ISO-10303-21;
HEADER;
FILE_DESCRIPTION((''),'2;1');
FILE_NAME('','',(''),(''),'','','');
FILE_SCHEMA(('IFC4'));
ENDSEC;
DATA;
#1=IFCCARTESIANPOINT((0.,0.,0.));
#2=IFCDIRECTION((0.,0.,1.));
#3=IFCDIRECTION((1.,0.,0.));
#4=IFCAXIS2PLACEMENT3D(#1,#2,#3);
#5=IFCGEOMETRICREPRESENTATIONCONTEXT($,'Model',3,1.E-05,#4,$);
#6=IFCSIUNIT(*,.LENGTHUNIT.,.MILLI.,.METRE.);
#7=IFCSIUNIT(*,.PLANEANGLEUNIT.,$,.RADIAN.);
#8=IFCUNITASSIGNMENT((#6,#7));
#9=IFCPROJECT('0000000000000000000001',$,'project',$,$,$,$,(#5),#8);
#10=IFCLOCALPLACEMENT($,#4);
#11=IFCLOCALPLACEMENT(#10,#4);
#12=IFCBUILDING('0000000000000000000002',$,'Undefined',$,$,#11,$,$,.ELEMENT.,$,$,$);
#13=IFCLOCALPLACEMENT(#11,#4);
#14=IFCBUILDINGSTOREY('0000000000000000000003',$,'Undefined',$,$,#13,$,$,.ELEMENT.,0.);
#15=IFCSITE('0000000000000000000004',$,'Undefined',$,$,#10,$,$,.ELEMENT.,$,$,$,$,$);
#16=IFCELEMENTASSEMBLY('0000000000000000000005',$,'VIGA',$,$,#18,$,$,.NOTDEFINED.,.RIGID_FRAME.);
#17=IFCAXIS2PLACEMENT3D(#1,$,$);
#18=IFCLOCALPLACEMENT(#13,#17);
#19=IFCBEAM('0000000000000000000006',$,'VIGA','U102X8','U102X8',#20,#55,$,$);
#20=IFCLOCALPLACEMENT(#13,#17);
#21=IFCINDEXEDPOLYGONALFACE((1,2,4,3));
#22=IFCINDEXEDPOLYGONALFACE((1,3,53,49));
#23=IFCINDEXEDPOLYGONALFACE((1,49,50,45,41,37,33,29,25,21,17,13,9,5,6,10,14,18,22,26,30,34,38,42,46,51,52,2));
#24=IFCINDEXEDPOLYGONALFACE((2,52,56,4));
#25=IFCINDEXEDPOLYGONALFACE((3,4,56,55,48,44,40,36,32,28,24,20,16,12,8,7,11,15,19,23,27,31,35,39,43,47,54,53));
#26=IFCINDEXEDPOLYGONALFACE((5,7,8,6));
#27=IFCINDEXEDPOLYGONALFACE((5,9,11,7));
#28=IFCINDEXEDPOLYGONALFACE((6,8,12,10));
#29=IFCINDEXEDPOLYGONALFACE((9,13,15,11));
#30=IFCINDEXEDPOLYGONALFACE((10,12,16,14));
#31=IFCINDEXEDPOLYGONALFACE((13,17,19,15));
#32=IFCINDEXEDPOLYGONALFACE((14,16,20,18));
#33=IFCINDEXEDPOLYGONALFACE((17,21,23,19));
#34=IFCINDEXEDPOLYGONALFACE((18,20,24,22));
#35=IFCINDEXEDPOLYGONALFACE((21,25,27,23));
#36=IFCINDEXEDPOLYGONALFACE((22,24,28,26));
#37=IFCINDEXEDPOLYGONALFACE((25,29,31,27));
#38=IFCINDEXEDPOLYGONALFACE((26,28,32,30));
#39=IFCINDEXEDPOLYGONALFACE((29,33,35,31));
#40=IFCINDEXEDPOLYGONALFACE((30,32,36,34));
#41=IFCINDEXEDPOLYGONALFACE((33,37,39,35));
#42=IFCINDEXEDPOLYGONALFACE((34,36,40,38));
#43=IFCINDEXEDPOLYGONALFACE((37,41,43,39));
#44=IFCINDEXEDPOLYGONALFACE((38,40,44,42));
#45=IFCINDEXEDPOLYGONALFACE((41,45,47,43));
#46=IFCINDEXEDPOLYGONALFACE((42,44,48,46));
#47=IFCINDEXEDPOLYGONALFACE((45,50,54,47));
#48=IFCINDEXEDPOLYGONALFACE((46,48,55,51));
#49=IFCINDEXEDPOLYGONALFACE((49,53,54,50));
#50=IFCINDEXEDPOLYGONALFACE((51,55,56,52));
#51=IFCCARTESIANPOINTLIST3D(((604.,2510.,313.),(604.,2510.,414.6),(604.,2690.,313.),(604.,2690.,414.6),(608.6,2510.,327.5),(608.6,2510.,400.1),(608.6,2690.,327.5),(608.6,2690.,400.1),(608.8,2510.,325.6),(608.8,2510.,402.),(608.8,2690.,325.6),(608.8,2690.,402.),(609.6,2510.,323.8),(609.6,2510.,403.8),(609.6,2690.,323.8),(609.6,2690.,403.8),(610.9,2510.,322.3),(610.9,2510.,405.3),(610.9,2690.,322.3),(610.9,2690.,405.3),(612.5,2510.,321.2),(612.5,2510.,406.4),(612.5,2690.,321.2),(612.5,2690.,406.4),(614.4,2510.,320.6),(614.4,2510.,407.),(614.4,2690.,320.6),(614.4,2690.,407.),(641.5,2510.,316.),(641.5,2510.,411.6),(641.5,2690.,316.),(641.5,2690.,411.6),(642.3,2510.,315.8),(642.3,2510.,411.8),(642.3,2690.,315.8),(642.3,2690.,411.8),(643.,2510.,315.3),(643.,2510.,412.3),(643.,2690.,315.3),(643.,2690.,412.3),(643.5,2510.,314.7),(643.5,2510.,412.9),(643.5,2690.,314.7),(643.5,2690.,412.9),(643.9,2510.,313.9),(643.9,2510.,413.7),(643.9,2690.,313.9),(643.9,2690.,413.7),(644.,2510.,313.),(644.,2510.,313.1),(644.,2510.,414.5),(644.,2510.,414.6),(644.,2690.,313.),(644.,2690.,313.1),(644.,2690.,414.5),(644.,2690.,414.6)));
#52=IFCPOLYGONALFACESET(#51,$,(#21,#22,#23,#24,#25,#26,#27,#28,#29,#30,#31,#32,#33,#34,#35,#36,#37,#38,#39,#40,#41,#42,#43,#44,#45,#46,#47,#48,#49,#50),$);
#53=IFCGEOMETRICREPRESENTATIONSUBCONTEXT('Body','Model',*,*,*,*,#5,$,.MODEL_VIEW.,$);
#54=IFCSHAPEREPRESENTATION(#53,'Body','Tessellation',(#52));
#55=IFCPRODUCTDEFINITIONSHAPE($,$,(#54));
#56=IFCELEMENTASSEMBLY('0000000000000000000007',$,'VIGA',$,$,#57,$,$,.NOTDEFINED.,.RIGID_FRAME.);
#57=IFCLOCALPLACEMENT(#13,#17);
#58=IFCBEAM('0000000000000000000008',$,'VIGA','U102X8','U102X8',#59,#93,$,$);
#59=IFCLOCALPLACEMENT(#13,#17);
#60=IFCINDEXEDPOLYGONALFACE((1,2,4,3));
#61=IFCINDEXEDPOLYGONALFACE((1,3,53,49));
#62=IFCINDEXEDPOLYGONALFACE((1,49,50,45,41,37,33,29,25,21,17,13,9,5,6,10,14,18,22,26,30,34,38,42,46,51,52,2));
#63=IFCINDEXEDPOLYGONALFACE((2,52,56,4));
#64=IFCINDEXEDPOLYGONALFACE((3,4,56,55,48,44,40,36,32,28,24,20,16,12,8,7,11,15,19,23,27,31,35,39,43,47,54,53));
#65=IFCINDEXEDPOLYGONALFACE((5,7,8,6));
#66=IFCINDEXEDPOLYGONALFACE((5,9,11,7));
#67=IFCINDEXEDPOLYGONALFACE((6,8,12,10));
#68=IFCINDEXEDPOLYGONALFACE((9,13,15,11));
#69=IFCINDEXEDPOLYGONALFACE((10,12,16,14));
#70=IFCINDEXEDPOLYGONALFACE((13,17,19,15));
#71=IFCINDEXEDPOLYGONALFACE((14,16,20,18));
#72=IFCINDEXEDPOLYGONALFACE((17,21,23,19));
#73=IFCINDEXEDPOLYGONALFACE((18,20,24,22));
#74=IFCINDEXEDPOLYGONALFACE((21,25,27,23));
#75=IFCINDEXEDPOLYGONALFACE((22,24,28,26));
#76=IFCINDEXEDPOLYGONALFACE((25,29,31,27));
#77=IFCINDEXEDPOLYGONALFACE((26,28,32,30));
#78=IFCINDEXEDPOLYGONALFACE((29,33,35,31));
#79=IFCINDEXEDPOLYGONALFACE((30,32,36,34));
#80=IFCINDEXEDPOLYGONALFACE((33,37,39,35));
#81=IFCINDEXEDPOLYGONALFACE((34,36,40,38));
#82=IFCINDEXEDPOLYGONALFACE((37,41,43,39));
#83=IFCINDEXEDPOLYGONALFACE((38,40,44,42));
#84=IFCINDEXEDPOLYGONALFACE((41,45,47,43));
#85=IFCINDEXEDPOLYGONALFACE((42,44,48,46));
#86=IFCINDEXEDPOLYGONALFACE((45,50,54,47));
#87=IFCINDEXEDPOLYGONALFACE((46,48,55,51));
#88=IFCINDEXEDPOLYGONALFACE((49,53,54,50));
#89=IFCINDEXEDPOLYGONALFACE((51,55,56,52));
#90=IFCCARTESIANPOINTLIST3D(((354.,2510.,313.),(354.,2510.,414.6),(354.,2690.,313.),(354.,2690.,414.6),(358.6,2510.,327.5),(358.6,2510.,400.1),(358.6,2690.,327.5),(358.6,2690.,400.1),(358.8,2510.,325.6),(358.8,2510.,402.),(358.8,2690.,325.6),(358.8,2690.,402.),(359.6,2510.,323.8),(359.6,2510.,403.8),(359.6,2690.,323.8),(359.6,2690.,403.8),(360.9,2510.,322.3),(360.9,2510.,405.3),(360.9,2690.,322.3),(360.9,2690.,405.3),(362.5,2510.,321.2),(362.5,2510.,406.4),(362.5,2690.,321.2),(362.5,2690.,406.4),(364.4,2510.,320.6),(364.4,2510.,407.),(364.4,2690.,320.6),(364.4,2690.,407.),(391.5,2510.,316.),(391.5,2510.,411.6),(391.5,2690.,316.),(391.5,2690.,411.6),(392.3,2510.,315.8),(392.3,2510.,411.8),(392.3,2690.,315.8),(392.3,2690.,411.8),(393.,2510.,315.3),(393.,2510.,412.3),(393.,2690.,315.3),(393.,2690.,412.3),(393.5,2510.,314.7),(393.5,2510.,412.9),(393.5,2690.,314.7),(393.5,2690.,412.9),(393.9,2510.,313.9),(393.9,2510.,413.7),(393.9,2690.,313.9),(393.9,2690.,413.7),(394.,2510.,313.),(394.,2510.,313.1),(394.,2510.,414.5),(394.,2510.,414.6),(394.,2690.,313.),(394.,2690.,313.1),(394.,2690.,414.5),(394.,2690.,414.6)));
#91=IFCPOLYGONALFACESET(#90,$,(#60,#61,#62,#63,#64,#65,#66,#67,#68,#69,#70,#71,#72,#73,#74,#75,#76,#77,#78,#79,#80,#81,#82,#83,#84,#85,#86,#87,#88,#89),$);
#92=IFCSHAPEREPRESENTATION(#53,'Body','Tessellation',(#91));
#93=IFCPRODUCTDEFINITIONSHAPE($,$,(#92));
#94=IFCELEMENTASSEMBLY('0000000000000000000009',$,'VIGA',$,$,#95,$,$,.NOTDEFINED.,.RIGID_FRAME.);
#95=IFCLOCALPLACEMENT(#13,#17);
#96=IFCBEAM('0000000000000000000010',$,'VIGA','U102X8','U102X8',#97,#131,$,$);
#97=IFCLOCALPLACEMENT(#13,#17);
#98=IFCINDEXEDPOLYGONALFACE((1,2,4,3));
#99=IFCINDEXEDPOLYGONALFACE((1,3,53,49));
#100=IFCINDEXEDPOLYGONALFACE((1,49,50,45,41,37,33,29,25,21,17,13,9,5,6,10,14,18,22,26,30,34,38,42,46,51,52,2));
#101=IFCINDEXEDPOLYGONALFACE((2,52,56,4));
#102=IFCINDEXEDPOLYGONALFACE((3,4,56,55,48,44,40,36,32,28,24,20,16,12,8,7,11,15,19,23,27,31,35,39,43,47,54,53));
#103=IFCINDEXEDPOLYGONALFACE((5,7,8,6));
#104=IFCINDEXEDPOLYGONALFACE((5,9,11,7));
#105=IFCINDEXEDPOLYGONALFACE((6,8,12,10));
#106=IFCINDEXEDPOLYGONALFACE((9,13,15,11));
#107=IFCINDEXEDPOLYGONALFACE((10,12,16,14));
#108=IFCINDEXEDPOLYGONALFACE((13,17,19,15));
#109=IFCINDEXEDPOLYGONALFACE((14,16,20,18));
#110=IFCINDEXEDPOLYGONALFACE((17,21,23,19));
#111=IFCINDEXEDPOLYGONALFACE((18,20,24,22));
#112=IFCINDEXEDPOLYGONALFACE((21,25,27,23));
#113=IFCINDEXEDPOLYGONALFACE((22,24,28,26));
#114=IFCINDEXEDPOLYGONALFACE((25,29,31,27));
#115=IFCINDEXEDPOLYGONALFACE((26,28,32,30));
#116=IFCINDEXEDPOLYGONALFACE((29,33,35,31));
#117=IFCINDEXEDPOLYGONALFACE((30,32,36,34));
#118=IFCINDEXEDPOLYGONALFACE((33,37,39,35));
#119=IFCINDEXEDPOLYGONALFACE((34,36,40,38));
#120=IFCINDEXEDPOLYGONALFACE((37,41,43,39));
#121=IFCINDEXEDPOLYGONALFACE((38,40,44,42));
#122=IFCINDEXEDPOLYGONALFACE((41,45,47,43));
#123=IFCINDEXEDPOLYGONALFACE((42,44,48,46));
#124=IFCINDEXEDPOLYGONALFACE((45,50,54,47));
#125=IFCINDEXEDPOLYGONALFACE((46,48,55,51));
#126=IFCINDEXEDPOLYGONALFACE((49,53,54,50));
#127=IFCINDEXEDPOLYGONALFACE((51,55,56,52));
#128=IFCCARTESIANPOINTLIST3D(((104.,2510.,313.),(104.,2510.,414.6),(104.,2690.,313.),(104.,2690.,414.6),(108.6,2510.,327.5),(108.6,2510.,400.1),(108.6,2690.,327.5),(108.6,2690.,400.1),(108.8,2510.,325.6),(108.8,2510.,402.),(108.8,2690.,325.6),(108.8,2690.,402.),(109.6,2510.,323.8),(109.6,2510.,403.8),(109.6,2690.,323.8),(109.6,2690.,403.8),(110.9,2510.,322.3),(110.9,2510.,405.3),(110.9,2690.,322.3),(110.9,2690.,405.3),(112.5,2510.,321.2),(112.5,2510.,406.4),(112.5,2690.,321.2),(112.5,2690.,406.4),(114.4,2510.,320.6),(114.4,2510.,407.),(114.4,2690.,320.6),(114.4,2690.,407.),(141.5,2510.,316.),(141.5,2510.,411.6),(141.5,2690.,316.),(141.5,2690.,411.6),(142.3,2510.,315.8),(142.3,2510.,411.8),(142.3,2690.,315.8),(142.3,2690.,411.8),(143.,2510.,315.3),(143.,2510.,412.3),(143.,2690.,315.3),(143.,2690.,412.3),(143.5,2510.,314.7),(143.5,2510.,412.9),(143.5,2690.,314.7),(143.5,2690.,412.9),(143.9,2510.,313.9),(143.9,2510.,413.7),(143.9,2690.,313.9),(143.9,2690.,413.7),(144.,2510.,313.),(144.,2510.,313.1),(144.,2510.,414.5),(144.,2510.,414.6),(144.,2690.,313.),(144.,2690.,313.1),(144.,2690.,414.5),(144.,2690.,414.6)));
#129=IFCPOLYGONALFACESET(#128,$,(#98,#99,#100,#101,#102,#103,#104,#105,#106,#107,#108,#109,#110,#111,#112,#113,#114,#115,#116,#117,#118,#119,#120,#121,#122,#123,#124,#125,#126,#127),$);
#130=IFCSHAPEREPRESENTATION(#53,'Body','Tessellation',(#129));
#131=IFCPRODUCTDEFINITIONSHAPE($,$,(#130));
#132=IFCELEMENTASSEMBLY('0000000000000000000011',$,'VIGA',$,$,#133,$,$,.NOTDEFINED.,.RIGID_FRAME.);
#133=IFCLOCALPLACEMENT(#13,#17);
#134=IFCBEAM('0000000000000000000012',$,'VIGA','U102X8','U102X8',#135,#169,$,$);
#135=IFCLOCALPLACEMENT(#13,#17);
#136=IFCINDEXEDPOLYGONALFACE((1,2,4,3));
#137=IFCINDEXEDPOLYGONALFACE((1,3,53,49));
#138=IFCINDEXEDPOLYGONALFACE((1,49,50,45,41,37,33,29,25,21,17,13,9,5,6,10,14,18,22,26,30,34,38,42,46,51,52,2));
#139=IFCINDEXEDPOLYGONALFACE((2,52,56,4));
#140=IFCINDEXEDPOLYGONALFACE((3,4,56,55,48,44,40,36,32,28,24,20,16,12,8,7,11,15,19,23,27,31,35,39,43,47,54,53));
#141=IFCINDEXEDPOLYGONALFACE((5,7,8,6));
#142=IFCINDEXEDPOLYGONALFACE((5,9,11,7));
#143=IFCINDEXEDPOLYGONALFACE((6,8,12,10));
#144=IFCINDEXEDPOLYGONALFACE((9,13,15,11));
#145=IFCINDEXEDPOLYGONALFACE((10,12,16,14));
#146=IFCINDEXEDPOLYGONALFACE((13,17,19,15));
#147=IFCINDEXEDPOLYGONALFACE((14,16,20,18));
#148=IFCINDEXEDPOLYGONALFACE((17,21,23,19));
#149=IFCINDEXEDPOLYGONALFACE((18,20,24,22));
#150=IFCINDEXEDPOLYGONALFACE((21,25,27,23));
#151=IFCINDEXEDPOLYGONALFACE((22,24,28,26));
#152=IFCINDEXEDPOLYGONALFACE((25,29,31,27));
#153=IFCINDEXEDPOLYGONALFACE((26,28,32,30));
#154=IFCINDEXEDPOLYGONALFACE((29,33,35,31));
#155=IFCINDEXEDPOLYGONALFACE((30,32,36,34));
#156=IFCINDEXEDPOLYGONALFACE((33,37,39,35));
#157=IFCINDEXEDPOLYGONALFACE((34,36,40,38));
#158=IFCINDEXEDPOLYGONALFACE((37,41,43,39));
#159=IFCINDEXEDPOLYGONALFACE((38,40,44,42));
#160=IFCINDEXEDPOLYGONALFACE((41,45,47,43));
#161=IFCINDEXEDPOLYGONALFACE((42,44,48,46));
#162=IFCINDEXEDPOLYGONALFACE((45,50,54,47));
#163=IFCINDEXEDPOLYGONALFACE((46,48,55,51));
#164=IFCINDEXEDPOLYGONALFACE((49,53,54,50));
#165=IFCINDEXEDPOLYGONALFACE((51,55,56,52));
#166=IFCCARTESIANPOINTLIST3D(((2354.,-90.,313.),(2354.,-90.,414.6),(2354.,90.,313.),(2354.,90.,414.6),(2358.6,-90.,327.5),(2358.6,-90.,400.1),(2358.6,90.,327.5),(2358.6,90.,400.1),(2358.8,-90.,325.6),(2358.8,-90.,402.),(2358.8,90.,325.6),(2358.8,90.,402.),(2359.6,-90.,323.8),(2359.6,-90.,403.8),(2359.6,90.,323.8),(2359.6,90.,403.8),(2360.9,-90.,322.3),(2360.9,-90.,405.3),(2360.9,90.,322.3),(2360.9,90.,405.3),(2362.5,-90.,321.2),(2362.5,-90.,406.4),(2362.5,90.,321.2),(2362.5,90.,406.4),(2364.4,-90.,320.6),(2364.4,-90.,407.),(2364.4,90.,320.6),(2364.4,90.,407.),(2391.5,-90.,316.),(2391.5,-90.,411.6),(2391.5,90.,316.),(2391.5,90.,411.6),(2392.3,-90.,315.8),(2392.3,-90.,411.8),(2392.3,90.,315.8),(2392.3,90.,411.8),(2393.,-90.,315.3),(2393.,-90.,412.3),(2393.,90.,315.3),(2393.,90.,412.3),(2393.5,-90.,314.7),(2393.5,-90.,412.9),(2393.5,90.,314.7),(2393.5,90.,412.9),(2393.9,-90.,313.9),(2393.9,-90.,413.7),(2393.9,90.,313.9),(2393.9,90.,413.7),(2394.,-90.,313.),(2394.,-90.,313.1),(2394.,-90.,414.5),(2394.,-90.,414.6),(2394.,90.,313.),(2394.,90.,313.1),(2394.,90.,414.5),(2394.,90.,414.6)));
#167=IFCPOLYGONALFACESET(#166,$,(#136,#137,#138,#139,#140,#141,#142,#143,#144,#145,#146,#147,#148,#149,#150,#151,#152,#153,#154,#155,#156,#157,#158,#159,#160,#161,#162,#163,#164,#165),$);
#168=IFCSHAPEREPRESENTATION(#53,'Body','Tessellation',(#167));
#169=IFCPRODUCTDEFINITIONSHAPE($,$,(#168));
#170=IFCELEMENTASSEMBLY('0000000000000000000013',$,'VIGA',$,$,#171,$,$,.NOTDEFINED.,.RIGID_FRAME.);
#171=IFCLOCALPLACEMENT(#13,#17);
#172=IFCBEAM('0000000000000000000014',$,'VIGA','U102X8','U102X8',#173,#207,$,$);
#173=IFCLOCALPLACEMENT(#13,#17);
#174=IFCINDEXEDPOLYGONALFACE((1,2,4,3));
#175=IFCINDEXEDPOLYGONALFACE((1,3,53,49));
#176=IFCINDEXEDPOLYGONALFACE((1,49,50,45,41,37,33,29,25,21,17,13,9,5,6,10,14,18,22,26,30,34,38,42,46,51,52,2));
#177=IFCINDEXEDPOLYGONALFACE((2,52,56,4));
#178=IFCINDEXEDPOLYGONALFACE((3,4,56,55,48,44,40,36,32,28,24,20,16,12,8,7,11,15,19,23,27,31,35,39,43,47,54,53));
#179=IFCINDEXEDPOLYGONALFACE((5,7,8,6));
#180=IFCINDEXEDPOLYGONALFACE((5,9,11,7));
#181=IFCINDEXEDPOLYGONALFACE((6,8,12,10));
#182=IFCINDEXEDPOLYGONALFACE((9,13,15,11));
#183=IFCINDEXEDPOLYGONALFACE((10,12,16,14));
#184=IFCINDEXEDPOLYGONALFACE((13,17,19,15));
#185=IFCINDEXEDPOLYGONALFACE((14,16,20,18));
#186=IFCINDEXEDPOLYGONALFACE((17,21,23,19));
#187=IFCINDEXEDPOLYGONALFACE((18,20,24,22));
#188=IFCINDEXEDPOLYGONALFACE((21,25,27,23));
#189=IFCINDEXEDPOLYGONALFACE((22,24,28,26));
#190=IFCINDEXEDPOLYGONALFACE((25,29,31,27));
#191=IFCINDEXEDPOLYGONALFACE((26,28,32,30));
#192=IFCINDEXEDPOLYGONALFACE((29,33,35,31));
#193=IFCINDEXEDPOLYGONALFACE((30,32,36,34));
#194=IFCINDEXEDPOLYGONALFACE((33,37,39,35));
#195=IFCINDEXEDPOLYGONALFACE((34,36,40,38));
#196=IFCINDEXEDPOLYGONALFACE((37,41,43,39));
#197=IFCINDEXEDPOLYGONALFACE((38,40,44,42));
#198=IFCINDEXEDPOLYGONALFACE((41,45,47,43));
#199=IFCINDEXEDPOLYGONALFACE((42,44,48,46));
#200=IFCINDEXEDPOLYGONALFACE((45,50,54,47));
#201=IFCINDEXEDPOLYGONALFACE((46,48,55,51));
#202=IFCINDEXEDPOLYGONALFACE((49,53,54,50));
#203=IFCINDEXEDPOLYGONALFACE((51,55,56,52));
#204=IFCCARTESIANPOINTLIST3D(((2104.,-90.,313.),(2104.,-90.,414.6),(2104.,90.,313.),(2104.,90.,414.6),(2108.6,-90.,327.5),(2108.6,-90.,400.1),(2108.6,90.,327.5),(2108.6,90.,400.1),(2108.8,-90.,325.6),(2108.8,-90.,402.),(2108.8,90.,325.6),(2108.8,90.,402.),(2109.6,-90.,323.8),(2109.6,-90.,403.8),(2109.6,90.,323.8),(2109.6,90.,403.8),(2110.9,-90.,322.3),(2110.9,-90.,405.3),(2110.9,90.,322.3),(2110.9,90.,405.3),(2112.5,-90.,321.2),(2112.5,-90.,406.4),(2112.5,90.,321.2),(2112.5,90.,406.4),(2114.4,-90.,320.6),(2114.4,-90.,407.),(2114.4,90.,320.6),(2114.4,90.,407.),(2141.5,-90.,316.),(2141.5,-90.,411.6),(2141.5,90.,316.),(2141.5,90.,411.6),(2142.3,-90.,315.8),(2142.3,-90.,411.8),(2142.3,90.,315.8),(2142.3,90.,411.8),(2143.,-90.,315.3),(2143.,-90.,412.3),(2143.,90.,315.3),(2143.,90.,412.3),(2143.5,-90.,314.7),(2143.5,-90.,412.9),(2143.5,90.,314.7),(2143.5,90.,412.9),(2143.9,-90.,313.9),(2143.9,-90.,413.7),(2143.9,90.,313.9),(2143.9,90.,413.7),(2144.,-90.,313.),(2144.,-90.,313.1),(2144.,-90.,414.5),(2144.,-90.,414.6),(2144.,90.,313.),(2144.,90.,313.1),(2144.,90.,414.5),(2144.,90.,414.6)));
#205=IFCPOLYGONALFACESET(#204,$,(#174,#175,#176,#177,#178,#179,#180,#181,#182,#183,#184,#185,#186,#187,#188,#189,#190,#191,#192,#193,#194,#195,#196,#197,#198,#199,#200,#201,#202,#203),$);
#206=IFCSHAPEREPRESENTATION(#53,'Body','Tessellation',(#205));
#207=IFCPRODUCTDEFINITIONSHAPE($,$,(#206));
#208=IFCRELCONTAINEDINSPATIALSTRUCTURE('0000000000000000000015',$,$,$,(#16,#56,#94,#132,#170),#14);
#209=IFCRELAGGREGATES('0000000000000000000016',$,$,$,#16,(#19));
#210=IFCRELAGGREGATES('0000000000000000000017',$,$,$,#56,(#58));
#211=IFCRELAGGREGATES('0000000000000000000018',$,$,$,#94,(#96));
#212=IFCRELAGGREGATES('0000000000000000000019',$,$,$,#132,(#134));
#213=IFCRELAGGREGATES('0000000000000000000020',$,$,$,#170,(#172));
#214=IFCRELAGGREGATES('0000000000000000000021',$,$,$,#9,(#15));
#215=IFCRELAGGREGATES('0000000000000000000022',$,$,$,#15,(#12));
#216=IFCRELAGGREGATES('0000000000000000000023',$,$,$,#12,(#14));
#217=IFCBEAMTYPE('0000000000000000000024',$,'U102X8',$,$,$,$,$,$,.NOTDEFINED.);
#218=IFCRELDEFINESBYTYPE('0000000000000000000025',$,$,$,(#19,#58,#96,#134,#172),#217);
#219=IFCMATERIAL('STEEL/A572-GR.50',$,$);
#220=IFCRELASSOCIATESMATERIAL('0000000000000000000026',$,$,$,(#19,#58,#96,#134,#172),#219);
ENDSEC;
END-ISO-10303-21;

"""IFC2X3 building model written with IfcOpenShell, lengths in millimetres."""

from ifc_helpers import new_model, si_unit, frame, origin_with_axes, origin_2d_with_axis, place, context, subcontext, project, spatial, u_section, extrude, material, type_object, element, aggregate, save


model = new_model("IFC2X3")

# Units and contexts
model_context = context("Model", 3, precision=1e-05, world=origin_with_axes())
body_context = subcontext(model_context, "Body", "Model", "MODEL_VIEW")
ifc_project = project(units=[si_unit("LENGTHUNIT", "METRE", prefix="MILLI"), si_unit("PLANEANGLEUNIT", "RADIAN")], contexts=[model_context])

# Site, building, storey
site_placement = place(None, origin_with_axes())
site = spatial("IfcSite", under=ifc_project, at=site_placement, Name="Undefined", CompositionType="ELEMENT")
building_placement = place(site_placement, origin_with_axes())
building = spatial("IfcBuilding", under=site, at=building_placement, Name="Undefined", CompositionType="ELEMENT")
storey_placement = place(building_placement, origin_with_axes())
storey = spatial("IfcBuildingStorey", under=building, at=storey_placement, Name="Undefined", CompositionType="ELEMENT", Elevation=0.0)

# Element assemblies, beams
ifc_material_1 = material(Name="STEEL/A572-GR.50")
beam_type_1 = type_object("IfcBeamType", Name="U102X8", PredefinedType="NOTDEFINED")
assembly_1_placement = place(storey_placement, origin_with_axes())
assembly_1 = element("IfcElementAssembly", 1, at=assembly_1_placement, inside=storey, Name="VIGA", AssemblyPlace="NOTDEFINED", PredefinedType="RIGID_FRAME")
beam_1_placement = place(assembly_1_placement, frame((624.0, 2510.0, 363.8), z_axis=(0.0, 0.0, 1.0), x_axis=(0.0, 1.0, 0.0)))
beam_1 = element("IfcBeam", 2, at=beam_1_placement, type_object=beam_type_1, material=ifc_material_1, Name="VIGA", Description="U102X8", ObjectType="U102X8", context=body_context, shape_type="SweptSolid", body=[
    extrude(u_section(Depth=101.6, FlangeWidth=40.0, WebThickness=4.6, FlangeThickness=6.0, FilletRadius=7.0, EdgeRadius=3.0, FlangeSlope=0.16839, at=origin_2d_with_axis()), frame((180.0, 0.0, 0.0), z_axis=(-1.0, 0.0, 0.0), x_axis=(0.0, -1.0, 0.0)), (0.0, 0.0, 1.0), 180.0),
])
aggregate(assembly_1, [beam_1])
assembly_2_placement = place(storey_placement, origin_with_axes())
assembly_2 = element("IfcElementAssembly", 3, at=assembly_2_placement, inside=storey, Name="VIGA", AssemblyPlace="NOTDEFINED", PredefinedType="RIGID_FRAME")
beam_2_placement = place(assembly_2_placement, frame((374.0, 2510.0, 363.8), z_axis=(0.0, 0.0, 1.0), x_axis=(0.0, 1.0, 0.0)))
beam_2 = element("IfcBeam", 4, at=beam_2_placement, type_object=beam_type_1, material=ifc_material_1, Name="VIGA", Description="U102X8", ObjectType="U102X8", context=body_context, shape_type="SweptSolid", body=[
    extrude(u_section(Depth=101.6, FlangeWidth=40.0, WebThickness=4.6, FlangeThickness=6.0, FilletRadius=7.0, EdgeRadius=3.0, FlangeSlope=0.16839, at=origin_2d_with_axis()), frame((180.0, 0.0, 0.0), z_axis=(-1.0, 0.0, 0.0), x_axis=(0.0, -1.0, 0.0)), (0.0, 0.0, 1.0), 180.0),
])
aggregate(assembly_2, [beam_2])
assembly_3_placement = place(storey_placement, origin_with_axes())
assembly_3 = element("IfcElementAssembly", 5, at=assembly_3_placement, inside=storey, Name="VIGA", AssemblyPlace="NOTDEFINED", PredefinedType="RIGID_FRAME")
beam_3_placement = place(assembly_3_placement, frame((124.0, 2510.0, 363.8), z_axis=(0.0, 0.0, 1.0), x_axis=(0.0, 1.0, 0.0)))
beam_3 = element("IfcBeam", 6, at=beam_3_placement, type_object=beam_type_1, material=ifc_material_1, Name="VIGA", Description="U102X8", ObjectType="U102X8", context=body_context, shape_type="SweptSolid", body=[
    extrude(u_section(Depth=101.6, FlangeWidth=40.0, WebThickness=4.6, FlangeThickness=6.0, FilletRadius=7.0, EdgeRadius=3.0, FlangeSlope=0.16839, at=origin_2d_with_axis()), frame((180.0, 0.0, 0.0), z_axis=(-1.0, 0.0, 0.0), x_axis=(0.0, -1.0, 0.0)), (0.0, 0.0, 1.0), 180.0),
])
aggregate(assembly_3, [beam_3])
assembly_4_placement = place(storey_placement, origin_with_axes())
assembly_4 = element("IfcElementAssembly", 7, at=assembly_4_placement, inside=storey, Name="VIGA", AssemblyPlace="NOTDEFINED", PredefinedType="RIGID_FRAME")
beam_4_placement = place(assembly_4_placement, frame((2374.0, -90.0, 363.8), z_axis=(0.0, 0.0, 1.0), x_axis=(0.0, 1.0, 0.0)))
beam_4 = element("IfcBeam", 8, at=beam_4_placement, type_object=beam_type_1, material=ifc_material_1, Name="VIGA", Description="U102X8", ObjectType="U102X8", context=body_context, shape_type="SweptSolid", body=[
    extrude(u_section(Depth=101.6, FlangeWidth=40.0, WebThickness=4.6, FlangeThickness=6.0, FilletRadius=7.0, EdgeRadius=3.0, FlangeSlope=0.16839, at=origin_2d_with_axis()), frame((180.0, 0.0, 0.0), z_axis=(-1.0, 0.0, 0.0), x_axis=(0.0, -1.0, 0.0)), (0.0, 0.0, 1.0), 180.0),
])
aggregate(assembly_4, [beam_4])
assembly_5_placement = place(storey_placement, origin_with_axes())
assembly_5 = element("IfcElementAssembly", 9, at=assembly_5_placement, inside=storey, Name="VIGA", AssemblyPlace="NOTDEFINED", PredefinedType="RIGID_FRAME")
beam_5_placement = place(assembly_5_placement, frame((2124.0, -90.0, 363.8), z_axis=(0.0, 0.0, 1.0), x_axis=(0.0, 1.0, 0.0)))
beam_5 = element("IfcBeam", 10, at=beam_5_placement, type_object=beam_type_1, material=ifc_material_1, Name="VIGA", Description="U102X8", ObjectType="U102X8", context=body_context, shape_type="SweptSolid", body=[
    extrude(u_section(Depth=101.6, FlangeWidth=40.0, WebThickness=4.6, FlangeThickness=6.0, FilletRadius=7.0, EdgeRadius=3.0, FlangeSlope=0.16839, at=origin_2d_with_axis()), frame((180.0, 0.0, 0.0), z_axis=(-1.0, 0.0, 0.0), x_axis=(0.0, -1.0, 0.0)), (0.0, 0.0, 1.0), 180.0),
])
aggregate(assembly_5, [beam_5])

save(model, "model.ifc")
